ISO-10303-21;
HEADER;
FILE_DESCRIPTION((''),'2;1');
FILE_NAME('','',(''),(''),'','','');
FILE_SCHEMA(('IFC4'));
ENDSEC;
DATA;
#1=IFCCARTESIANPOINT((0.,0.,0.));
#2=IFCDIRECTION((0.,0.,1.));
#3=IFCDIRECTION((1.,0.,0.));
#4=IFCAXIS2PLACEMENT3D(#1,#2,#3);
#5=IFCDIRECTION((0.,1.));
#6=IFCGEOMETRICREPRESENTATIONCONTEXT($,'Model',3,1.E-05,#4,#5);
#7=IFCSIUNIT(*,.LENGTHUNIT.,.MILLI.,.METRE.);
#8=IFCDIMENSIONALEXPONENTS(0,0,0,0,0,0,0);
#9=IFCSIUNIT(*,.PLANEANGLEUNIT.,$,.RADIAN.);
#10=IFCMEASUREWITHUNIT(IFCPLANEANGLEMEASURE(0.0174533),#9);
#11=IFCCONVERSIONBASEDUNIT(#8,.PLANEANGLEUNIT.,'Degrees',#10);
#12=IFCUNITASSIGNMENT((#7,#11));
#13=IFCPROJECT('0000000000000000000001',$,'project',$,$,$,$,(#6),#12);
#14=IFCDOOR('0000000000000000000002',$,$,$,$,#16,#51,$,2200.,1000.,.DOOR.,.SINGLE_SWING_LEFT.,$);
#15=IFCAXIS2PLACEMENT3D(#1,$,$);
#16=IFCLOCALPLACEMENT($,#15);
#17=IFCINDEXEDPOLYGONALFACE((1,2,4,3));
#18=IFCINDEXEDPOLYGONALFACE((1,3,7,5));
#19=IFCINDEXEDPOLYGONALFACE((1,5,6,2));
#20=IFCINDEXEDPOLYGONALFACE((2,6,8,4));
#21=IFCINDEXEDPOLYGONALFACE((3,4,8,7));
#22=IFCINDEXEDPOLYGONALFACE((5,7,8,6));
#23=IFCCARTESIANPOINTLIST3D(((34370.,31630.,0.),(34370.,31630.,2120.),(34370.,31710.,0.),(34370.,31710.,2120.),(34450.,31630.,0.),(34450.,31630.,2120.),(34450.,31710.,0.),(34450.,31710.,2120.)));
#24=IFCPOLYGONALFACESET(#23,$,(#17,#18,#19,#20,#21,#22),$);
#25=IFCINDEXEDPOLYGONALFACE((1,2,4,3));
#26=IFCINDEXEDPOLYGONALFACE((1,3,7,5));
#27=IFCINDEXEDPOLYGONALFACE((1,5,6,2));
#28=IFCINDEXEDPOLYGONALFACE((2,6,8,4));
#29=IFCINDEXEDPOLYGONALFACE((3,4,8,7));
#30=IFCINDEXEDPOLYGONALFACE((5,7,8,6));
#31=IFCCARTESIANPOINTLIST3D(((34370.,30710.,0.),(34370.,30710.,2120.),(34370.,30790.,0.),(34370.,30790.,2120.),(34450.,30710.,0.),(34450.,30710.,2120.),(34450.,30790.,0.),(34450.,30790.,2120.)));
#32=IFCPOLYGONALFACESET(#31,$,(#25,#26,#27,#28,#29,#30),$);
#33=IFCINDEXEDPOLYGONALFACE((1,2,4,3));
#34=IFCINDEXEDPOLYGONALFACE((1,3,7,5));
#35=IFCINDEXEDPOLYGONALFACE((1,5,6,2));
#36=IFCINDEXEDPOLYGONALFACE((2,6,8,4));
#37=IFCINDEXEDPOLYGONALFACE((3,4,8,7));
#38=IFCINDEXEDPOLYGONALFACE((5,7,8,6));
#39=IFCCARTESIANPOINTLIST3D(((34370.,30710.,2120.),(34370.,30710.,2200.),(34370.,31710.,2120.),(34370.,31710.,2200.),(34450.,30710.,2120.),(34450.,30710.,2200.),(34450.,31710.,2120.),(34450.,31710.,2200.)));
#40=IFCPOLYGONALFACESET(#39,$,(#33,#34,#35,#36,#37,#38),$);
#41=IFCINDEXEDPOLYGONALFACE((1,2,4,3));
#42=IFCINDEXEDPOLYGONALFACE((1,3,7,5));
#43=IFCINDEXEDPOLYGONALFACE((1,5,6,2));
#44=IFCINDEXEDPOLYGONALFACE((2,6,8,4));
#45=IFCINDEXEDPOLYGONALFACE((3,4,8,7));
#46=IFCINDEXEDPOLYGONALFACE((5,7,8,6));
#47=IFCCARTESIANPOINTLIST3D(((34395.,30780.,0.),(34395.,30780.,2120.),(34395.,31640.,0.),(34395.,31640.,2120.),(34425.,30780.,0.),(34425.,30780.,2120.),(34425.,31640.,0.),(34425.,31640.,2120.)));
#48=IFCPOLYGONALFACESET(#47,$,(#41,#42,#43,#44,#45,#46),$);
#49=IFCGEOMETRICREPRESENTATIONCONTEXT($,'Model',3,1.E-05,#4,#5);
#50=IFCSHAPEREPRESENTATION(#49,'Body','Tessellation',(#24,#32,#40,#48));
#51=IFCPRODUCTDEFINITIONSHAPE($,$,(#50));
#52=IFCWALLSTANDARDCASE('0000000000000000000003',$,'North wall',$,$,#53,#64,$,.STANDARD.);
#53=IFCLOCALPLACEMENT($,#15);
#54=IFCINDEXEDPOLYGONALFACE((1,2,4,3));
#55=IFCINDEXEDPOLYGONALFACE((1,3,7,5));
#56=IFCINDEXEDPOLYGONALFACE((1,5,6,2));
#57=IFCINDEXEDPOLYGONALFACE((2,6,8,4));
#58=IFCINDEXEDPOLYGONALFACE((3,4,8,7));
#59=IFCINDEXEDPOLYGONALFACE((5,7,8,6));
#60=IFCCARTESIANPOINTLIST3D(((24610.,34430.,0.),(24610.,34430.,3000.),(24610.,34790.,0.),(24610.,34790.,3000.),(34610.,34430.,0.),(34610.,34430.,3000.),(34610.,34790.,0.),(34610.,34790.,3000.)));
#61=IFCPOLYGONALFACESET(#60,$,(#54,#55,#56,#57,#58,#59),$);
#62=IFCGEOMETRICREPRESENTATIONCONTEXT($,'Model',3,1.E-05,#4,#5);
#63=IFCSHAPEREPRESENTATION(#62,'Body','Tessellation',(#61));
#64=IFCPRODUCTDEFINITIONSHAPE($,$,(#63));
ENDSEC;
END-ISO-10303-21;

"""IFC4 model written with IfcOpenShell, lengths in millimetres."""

from ifc_helpers import new_model, entity, si_unit, converted_unit, direction, frame, origin_with_axes, place, context, project, polyline, outline, extrude, element, save


model = new_model("IFC4")

# Units and contexts
model_context_1 = context("Model", 3, precision=1e-05, world=origin_with_axes(), true_north=direction((0.0, 1.0)))
model_context_2 = context("Model", 3, precision=1e-05, world=origin_with_axes(), true_north=direction((0.0, 1.0)))
model_context_3 = context("Model", 3, precision=1e-05, world=origin_with_axes(), true_north=direction((0.0, 1.0)))
ifc_project = project(units=[si_unit("LENGTHUNIT", "METRE", prefix="MILLI"), converted_unit("PLANEANGLEUNIT", "Degrees", entity("IfcPlaneAngleMeasure", 0.0174533), si_unit("PLANEANGLEUNIT", "RADIAN"), dimensions=[0, 0, 0, 0, 0, 0, 0])], contexts=[model_context_1])

# Shared definitions
placement_1 = place(None, frame((29610.0, 29610.0, 0.0)))

# Door
door_1_placement = place(placement_1, frame((4800.0, 1600.0, 0.0), z_axis=(0.0, 0.0, 1.0), x_axis=(0.0, 1.0, 0.0)))
element("IfcDoor", 1, at=door_1_placement, OperationType="SINGLE_SWING_LEFT", OverallHeight=2200.0, OverallWidth=1000.0, PredefinedType="DOOR", context=model_context_2, shape_type="SweptSolid", body=[
    extrude(outline(polyline([(-40.0, -40.0), (40.0, -40.0), (40.0, 40.0), (-40.0, 40.0), (-40.0, -40.0), (-40.0, -40.0)])), frame((460.0, 0.0, 0.0), z_axis=(0.0, 0.0, 1.0), x_axis=(1.0, 0.0, 0.0)), (0.0, 0.0, 1.0), 2120.0),
    extrude(outline(polyline([(-40.0, -40.0), (40.0, -40.0), (40.0, 40.0), (-40.0, 40.0), (-40.0, -40.0), (-40.0, -40.0)])), frame((-460.0, 0.0, 0.0), z_axis=(0.0, 0.0, 1.0), x_axis=(1.0, 0.0, 0.0)), (0.0, 0.0, 1.0), 2120.0),
    extrude(outline(polyline([(-500.0, -40.0), (500.0, -40.0), (500.0, 40.0), (-500.0, 40.0), (-500.0, -40.0), (-500.0, -40.0)])), frame((0.0, 0.0, 2120.0), z_axis=(0.0, 0.0, 1.0), x_axis=(1.0, 0.0, 0.0)), (0.0, 0.0, 1.0), 80.0),
    extrude(outline(polyline([(-430.0, -15.0), (430.0, -15.0), (430.0, 15.0), (-430.0, 15.0), (-430.0, -15.0), (-430.0, -15.0)])), origin_with_axes(), (0.0, 0.0, 1.0), 2120.0),
])

# Wall
wall_1_placement = place(placement_1, frame((0.0, 5000.0, 0.0), z_axis=(0.0, 0.0, 1.0), x_axis=(1.0, 0.0, 0.0)))
element("IfcWallStandardCase", 2, at=wall_1_placement, Name="North wall", PredefinedType="STANDARD", context=model_context_3, shape_type="SweptSolid", body=[
    extrude(outline(polyline([(-5000.0, -180.0), (5000.0, -180.0), (5000.0, 180.0), (-5000.0, 180.0), (-5000.0, -180.0), (-5000.0, -180.0)])), origin_with_axes(), (0.0, 0.0, 1.0), 3000.0),
])

save(model, "model.ifc")
